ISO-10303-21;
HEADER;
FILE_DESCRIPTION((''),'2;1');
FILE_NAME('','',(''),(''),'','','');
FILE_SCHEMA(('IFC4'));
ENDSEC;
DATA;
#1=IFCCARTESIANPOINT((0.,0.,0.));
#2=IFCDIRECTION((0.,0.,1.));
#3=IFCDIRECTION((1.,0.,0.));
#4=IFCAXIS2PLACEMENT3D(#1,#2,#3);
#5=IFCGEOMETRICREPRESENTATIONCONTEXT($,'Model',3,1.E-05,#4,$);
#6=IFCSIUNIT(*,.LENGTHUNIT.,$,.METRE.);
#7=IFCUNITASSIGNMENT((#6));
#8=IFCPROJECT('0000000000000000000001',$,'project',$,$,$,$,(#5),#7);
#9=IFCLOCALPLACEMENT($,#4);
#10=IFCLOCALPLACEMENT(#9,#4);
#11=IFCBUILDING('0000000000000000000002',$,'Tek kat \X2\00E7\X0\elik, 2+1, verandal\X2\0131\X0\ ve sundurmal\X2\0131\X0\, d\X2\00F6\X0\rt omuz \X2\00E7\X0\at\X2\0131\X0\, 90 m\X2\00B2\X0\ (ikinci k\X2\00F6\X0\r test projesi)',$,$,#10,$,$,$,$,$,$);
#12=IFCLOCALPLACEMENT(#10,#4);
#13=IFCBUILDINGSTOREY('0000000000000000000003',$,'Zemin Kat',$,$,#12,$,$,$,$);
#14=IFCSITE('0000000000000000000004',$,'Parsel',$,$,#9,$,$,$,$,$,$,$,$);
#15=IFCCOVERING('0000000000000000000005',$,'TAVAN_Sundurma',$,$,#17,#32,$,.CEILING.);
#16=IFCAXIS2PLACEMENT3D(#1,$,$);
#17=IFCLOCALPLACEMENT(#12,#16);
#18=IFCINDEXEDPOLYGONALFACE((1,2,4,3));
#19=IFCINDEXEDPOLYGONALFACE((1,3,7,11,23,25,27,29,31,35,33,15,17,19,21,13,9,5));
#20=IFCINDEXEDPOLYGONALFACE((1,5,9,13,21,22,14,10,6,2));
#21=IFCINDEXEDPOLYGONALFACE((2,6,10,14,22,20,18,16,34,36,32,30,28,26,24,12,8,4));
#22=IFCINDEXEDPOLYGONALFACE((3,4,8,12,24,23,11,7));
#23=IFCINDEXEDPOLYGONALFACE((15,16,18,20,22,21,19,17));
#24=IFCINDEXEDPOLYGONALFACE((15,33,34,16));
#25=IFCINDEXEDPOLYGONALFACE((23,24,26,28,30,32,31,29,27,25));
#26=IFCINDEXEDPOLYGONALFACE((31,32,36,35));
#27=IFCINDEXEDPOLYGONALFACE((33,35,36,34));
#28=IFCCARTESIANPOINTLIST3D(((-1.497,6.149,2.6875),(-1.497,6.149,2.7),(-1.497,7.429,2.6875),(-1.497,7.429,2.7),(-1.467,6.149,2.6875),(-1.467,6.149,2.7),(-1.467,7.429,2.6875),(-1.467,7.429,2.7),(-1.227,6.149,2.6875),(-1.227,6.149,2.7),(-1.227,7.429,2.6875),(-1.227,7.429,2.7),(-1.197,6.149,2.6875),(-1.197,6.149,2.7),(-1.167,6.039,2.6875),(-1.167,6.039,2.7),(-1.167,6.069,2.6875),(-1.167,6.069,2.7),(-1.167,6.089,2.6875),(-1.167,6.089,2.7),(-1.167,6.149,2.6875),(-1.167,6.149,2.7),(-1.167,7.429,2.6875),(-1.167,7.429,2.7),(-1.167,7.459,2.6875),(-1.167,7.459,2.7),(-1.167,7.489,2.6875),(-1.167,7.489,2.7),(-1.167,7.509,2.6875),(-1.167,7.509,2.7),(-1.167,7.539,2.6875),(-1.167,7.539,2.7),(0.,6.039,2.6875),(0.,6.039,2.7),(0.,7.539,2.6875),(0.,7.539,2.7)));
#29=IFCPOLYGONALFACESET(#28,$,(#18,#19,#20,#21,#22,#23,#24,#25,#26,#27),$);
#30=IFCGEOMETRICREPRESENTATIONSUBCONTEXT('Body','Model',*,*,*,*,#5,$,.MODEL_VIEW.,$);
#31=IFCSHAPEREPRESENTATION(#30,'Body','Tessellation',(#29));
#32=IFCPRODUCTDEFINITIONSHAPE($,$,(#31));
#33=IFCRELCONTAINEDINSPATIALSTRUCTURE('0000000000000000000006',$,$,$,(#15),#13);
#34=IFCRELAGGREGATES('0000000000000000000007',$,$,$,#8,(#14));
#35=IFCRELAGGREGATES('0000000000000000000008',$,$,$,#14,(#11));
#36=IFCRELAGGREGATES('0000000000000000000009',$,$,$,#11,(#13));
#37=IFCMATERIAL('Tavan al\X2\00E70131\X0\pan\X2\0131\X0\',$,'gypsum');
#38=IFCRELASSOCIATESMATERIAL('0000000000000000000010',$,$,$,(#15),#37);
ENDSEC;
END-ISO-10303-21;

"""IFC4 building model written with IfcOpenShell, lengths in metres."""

from ifc_helpers import new_model, si_unit, frame, origin_with_axes, place, context, subcontext, project, spatial, line, indexed_curve, outline, extrude, material, element, save


model = new_model("IFC4")

# Units and contexts
model_context = context("Model", 3, precision=1e-05, world=origin_with_axes())
body_context = subcontext(model_context, "Body", "Model", "MODEL_VIEW")
ifc_project = project(units=[si_unit("LENGTHUNIT", "METRE")], contexts=[model_context])

# Site, building, storey
site_placement = place(None, origin_with_axes())
site = spatial("IfcSite", under=ifc_project, at=site_placement, Name="Parsel")
building_placement = place(site_placement, origin_with_axes())
building = spatial("IfcBuilding", under=site, at=building_placement, Name="Tek kat çelik, 2+1, verandalı ve sundurmalı, dört omuz çatı, 90 m² (ikinci kör test projesi)")
storey_placement = place(building_placement, origin_with_axes())
storey = spatial("IfcBuildingStorey", under=building, at=storey_placement, Name="Zemin Kat")

# Covering
ifc_material_1 = material(Name="Tavan alçıpanı", Category="gypsum")
covering_1_placement = place(storey_placement, origin_with_axes())
element("IfcCovering", 1, at=covering_1_placement, inside=storey, material=ifc_material_1, Name="TAVAN_Sundurma", PredefinedType="CEILING", context=body_context, shape_type="SweptSolid", body=[
    extrude(outline(indexed_curve([(-1.497, 7.429), (-1.467, 7.429), (-1.227, 7.429), (-1.167, 7.429), (-1.167, 7.459), (-1.167, 7.489), (-1.167, 7.509), (-1.167, 7.539), (0.0, 7.539), (0.0, 6.039), (-1.167, 6.039), (-1.167, 6.069), (-1.167, 6.089), (-1.167, 6.149), (-1.197, 6.149), (-1.227, 6.149), (-1.467, 6.149), (-1.497, 6.149)], segments=[line(1, 2, 3, 4, 5, 6, 7, 8, 9, 10, 11, 12, 13, 14, 15, 16, 17, 18, 1)])), frame((0.0, 0.0, 2.6875), z_axis=(0.0, 0.0, 1.0), x_axis=(1.0, 0.0, 0.0)), (0.0, 0.0, 1.0), 0.0125),
])

save(model, "model.ifc")
